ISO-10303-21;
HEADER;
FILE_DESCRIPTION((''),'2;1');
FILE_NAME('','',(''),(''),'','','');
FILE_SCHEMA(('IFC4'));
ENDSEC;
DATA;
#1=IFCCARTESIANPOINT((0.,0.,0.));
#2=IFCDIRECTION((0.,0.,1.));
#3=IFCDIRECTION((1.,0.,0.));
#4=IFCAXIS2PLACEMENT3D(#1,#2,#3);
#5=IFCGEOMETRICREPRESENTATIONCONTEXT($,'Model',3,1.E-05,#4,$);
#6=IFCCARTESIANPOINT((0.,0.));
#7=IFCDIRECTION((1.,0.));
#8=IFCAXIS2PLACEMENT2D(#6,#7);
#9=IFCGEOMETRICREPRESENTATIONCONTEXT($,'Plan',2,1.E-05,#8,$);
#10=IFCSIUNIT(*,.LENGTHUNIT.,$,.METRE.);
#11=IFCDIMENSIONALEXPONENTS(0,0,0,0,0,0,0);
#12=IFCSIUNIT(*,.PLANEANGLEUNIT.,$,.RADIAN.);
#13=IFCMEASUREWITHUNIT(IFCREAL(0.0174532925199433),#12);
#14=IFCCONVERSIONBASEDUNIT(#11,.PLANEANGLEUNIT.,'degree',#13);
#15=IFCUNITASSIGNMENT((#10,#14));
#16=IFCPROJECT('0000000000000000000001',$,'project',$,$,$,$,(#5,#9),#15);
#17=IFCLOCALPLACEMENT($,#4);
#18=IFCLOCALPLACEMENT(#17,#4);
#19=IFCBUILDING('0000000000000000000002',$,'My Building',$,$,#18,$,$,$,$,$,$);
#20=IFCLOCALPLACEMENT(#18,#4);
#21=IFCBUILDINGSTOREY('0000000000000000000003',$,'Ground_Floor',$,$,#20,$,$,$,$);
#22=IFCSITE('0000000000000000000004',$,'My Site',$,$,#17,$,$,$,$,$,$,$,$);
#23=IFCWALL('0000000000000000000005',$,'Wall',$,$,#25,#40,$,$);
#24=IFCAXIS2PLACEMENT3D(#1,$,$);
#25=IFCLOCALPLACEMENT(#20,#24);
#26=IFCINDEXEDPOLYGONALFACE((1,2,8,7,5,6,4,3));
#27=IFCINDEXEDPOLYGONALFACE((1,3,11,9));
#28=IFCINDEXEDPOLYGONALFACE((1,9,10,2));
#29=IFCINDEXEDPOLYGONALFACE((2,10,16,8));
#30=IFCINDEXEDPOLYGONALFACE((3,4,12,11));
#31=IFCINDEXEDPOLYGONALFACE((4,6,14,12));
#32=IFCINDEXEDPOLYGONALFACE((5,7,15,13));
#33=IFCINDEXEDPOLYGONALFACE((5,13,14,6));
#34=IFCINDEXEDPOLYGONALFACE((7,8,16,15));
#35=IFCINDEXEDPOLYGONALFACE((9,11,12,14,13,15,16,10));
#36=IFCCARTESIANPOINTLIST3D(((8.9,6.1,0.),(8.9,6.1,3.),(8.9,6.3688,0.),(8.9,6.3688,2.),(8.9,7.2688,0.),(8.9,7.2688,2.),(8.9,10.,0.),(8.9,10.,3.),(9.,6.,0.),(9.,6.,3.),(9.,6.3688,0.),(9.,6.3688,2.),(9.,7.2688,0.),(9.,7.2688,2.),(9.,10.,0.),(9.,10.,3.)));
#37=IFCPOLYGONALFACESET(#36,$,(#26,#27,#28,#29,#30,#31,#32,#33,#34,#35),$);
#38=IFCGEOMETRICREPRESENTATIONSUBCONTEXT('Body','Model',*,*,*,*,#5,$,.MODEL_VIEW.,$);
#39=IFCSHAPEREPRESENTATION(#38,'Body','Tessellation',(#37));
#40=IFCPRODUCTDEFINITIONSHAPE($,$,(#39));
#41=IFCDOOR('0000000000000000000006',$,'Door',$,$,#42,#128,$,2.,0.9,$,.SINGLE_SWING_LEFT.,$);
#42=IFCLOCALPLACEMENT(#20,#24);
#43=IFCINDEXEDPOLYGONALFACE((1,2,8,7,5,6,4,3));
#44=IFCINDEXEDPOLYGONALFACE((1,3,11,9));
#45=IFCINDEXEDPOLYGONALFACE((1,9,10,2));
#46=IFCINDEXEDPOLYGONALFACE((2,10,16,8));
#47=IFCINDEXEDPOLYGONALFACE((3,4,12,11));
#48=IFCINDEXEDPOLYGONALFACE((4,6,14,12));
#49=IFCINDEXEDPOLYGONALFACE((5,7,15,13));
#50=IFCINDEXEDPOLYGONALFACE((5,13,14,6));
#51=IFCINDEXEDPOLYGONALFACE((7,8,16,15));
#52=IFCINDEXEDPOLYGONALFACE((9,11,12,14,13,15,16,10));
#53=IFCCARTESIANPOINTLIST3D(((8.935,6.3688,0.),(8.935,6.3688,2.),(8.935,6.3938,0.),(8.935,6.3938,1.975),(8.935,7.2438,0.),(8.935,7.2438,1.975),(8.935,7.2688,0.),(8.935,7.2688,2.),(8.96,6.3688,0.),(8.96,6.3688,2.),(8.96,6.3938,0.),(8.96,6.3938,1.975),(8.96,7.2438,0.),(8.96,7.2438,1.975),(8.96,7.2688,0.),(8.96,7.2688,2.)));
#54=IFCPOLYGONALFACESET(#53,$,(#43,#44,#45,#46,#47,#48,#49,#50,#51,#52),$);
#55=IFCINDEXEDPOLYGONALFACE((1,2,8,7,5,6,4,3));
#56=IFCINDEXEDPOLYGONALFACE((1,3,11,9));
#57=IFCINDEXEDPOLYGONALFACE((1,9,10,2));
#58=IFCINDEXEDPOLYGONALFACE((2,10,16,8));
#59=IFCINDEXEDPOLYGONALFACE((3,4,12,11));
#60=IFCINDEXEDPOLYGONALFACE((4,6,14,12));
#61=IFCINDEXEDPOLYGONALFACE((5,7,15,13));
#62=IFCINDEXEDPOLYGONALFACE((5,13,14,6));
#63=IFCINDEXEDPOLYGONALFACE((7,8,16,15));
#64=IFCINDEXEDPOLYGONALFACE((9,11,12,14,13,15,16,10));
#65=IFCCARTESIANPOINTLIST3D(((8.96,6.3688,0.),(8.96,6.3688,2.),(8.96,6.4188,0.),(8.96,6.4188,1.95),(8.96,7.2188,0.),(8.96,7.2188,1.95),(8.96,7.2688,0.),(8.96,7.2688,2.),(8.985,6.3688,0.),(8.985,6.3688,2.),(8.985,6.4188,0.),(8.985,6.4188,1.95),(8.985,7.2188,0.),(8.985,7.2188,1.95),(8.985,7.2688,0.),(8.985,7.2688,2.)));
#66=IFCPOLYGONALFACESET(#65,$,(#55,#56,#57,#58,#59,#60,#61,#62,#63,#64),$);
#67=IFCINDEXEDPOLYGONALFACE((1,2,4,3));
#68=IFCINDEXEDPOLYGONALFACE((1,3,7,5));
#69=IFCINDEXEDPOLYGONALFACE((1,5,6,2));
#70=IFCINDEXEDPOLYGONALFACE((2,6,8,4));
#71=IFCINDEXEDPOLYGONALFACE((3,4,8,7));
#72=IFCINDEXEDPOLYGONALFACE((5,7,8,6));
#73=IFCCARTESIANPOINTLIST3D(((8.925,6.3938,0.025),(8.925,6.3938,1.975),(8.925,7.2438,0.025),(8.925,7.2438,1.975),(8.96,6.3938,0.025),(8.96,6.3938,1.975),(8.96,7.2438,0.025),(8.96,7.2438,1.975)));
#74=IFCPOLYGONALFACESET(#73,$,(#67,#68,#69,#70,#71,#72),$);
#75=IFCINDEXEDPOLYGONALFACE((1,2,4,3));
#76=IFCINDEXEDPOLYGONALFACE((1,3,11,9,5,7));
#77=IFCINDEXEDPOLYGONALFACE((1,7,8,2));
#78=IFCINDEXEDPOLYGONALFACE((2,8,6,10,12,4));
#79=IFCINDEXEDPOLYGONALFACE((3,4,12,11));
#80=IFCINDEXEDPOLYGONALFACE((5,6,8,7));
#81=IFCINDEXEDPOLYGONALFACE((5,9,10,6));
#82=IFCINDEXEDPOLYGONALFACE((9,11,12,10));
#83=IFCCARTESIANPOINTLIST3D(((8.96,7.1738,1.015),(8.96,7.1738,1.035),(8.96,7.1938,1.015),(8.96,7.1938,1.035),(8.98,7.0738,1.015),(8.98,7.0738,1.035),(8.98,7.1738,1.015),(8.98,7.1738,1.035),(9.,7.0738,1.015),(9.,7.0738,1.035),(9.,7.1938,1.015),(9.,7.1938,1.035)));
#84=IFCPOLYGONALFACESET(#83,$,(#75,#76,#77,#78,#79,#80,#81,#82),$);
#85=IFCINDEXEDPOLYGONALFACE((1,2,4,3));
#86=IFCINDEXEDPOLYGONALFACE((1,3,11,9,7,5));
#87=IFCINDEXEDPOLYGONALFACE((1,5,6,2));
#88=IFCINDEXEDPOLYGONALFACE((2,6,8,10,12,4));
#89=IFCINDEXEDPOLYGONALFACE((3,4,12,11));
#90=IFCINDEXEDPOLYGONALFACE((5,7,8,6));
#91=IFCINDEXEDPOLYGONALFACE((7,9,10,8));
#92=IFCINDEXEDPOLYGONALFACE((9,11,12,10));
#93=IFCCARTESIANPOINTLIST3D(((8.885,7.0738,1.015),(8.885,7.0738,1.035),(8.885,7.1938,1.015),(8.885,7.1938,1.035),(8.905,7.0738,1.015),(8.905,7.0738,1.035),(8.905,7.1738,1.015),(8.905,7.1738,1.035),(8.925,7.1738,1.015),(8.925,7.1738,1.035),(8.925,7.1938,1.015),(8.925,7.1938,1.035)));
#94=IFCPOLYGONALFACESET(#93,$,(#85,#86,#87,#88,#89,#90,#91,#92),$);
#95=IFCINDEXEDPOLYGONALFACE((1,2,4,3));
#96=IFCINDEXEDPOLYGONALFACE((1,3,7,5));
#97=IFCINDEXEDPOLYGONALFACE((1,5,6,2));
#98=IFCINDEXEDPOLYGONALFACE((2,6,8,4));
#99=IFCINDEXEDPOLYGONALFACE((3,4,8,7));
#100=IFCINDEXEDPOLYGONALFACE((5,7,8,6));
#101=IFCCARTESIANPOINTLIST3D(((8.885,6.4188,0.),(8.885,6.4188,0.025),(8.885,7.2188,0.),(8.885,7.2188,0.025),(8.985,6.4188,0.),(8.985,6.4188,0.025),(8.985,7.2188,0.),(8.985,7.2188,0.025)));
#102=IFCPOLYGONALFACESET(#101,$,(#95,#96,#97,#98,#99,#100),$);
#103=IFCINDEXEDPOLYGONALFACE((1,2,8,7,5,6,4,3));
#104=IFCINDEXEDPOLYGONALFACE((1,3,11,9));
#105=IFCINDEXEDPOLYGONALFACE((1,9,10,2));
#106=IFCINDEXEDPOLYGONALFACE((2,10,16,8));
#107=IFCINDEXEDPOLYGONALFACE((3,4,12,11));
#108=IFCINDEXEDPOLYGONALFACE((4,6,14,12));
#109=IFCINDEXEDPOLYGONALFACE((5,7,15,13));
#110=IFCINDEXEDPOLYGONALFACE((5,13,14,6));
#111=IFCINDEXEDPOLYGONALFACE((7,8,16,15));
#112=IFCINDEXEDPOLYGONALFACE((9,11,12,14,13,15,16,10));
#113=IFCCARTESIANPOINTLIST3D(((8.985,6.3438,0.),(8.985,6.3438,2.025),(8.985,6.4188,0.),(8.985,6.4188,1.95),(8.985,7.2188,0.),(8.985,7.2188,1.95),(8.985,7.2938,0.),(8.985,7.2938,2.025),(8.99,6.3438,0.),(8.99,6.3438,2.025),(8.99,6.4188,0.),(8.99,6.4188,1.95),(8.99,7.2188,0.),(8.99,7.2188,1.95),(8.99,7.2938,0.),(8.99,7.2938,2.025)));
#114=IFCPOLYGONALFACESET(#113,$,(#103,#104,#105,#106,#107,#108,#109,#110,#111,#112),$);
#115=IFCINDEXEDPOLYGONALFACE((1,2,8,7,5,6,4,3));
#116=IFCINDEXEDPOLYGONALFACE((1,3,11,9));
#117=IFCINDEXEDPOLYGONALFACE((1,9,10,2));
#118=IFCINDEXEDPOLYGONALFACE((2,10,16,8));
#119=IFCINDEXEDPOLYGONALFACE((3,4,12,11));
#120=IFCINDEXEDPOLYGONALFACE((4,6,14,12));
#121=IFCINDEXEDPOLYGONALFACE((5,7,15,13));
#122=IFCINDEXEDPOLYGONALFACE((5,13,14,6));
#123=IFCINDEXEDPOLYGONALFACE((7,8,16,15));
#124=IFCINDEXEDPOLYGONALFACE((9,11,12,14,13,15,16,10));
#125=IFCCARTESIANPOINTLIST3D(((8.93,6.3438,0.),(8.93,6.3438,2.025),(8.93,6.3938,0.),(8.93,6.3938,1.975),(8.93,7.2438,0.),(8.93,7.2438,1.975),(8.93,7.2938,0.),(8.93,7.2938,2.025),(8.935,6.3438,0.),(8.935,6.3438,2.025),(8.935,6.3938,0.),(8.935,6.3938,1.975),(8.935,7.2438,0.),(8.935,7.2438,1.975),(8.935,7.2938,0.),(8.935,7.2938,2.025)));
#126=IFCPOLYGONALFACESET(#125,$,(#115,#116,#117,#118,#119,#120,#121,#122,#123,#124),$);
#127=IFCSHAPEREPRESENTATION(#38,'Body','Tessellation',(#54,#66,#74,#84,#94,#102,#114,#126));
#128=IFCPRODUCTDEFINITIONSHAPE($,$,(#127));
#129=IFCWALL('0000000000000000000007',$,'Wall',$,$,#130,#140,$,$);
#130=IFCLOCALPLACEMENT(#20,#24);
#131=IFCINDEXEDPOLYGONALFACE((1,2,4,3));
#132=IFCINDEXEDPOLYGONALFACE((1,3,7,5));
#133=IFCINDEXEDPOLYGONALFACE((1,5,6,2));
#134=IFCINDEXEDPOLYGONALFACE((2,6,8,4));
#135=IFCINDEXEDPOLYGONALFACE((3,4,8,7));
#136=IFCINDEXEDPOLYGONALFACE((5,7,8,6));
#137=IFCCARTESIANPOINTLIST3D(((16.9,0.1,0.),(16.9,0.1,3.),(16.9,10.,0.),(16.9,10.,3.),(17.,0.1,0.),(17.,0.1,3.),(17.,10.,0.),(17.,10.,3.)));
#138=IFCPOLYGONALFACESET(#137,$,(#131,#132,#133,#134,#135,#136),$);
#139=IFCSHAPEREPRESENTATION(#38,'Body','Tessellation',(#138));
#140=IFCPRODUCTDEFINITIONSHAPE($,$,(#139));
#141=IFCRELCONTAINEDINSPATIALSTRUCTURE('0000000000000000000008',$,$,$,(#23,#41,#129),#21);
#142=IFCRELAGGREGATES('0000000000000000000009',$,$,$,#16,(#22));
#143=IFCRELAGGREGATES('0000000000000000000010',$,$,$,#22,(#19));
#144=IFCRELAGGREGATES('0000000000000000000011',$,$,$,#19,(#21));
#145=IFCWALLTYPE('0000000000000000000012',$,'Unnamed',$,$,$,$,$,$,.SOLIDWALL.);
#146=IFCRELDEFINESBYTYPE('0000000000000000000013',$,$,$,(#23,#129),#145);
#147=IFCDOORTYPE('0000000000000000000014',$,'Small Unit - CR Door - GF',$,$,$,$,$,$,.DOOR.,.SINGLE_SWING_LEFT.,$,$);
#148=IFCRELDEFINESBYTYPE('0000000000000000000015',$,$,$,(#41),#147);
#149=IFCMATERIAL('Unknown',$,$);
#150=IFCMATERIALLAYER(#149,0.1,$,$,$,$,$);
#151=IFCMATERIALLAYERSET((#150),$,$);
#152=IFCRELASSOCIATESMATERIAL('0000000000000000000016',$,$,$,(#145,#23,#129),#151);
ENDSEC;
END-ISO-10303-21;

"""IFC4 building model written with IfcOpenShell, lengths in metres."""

from ifc_helpers import new_model, entity, si_unit, converted_unit, frame, origin_with_axes, origin_2d_with_axis, place, context, subcontext, project, spatial, line, indexed_curve, outline, extrude, shape, source, transform, mapped, material, layer, layer_set, layer_usage, type_object, type_shapes, element, fill, save


model = new_model("IFC4")

# Units and contexts
model_context = context("Model", 3, precision=1e-05, world=origin_with_axes())
plan_context = context("Plan", 2, precision=1e-05, world=origin_2d_with_axis())
body_context_1 = subcontext(model_context, "Body", "Model", "MODEL_VIEW")
body_context_2 = subcontext(plan_context, "Body", "Plan", "PLAN_VIEW")
ifc_project = project(units=[si_unit("LENGTHUNIT", "METRE"), converted_unit("PLANEANGLEUNIT", "degree", entity("IfcReal", 0.0174532925199433), si_unit("PLANEANGLEUNIT", "RADIAN"), dimensions=[0, 0, 0, 0, 0, 0, 0])], contexts=[model_context, plan_context])

# Site, building, storey
site_placement = place(None, origin_with_axes())
site = spatial("IfcSite", under=ifc_project, at=site_placement, Name="My Site")
building_placement = place(site_placement, origin_with_axes())
building = spatial("IfcBuilding", under=site, at=building_placement, Name="My Building")
storey_placement = place(building_placement, origin_with_axes())
storey = spatial("IfcBuildingStorey", under=building, at=storey_placement, Name="Ground_Floor")

# Shared definitions
ifc_material = material(Name="Unknown")
ifc_layer = layer(ifc_material, 0.1)
ifc_layer_set = layer_set([ifc_layer])
wall_type = type_object("IfcWallType", Name="Unnamed", PredefinedType="SOLIDWALL", material=ifc_layer_set)

# Wall, opening, door
ifc_layer_usage_1 = layer_usage(ifc_layer_set, "AXIS2", "POSITIVE", 0.0)
wall_1_placement = place(storey_placement, frame((9.0, 6.0, 0.0), z_axis=(0.0, 0.0, 1.0), x_axis=(0.0, 1.0, 0.0)))
wall_1 = element("IfcWall", 1, at=wall_1_placement, inside=storey, type_object=wall_type, material=ifc_layer_usage_1, Name="Wall", context=body_context_1, shape_type="SweptSolid", body=[
    extrude(outline(indexed_curve([(0.0, 0.0), (0.1, 0.1), (4.0, 0.1), (4.0, 0.0)], segments=[line(1, 2, 3, 4, 1)])), origin_with_axes(), (0.0, 0.0, 1.0), 3.0),
])
shared_shape_1 = source(origin_with_axes(), body_context_1, "Body", "SweptSolid", [
    extrude(outline(indexed_curve([(0.0, 0.0), (0.9, 0.0), (0.9, 2.0), (0.0, 2.0)], segments=[line(1, 2, 3, 4, 1)])), frame((0.0, -0.6, 0.0), z_axis=(0.0, -1.0, 0.0), x_axis=(1.0, 0.0, 0.0)), (0.0, 0.0, -1.0), 1.2),
])
opening_1_placement = place(wall_1_placement, frame((0.3688, 0.015, 0.0), z_axis=(0.0, 0.0, 1.0), x_axis=(1.0, 0.0, 0.0)))
opening_1 = element("IfcOpeningElement", 2, at=opening_1_placement, cuts=wall_1, PredefinedType="OPENING", context=body_context_1, shape_type="MappedRepresentation", body=[
    mapped(shared_shape_1, transform((0.0, 0.0, 0.0), x_axis=(1.0, 0.0, 0.0), y_axis=(0.0, 1.0, 0.0), z_axis=(0.0, 0.0, 1.0), scale=1.0)),
])
door_type_1 = type_object("IfcDoorType", Name="Small Unit - CR Door - GF", OperationType="SINGLE_SWING_LEFT", PredefinedType="DOOR")
shared_shape_2 = source(origin_with_axes(), body_context_1, "Body", "SweptSolid", [
    extrude(outline(indexed_curve([(0.0, 0.0), (0.0, 2.0), (0.9, 2.0), (0.9, 0.0), (0.875, 0.0), (0.875, 1.975), (0.025, 1.975), (0.025, 0.0)], segments=[line(1, 2, 3, 4, 5, 6, 7, 8, 1)])), frame((0.0, 0.025, 0.0), z_axis=(0.0, -1.0, 0.0), x_axis=(1.0, 0.0, 0.0)), (0.0, 0.0, -1.0), 0.025),
    extrude(outline(indexed_curve([(0.0, 0.0), (0.0, 2.0), (0.9, 2.0), (0.9, 0.0), (0.85, 0.0), (0.85, 1.95), (0.05, 1.95), (0.05, 0.0)], segments=[line(1, 2, 3, 4, 5, 6, 7, 8, 1)])), frame((0.0, 0.0, 0.0), z_axis=(0.0, -1.0, 0.0), x_axis=(1.0, 0.0, 0.0)), (0.0, 0.0, -1.0), 0.025),
    extrude(outline(indexed_curve([(0.0, 0.0), (0.85, 0.0), (0.85, 0.035), (0.0, 0.035)], segments=[line(1, 2, 3, 4, 1)])), frame((0.025, 0.025, 0.025), z_axis=(0.0, 0.0, 1.0), x_axis=(1.0, 0.0, 0.0)), (0.0, 0.0, 1.0), 1.95),
    extrude(outline(indexed_curve([(0.0, 0.0), (0.0, -0.04), (-0.12, -0.04), (-0.12, -0.02), (-0.02, -0.02), (-0.02, 0.0)], segments=[line(1, 2, 3, 4, 5, 6, 1)])), frame((0.825, 0.025, 1.015), z_axis=(0.0, 0.0, 1.0), x_axis=(1.0, 0.0, 0.0)), (0.0, 0.0, 1.0), 0.02),
    extrude(outline(indexed_curve([(0.0, 0.0), (0.0, 0.04), (-0.12, 0.04), (-0.12, 0.02), (-0.02, 0.02), (-0.02, 0.0)], segments=[line(1, 2, 3, 4, 5, 6, 1)])), frame((0.825, 0.06, 1.015), z_axis=(0.0, 0.0, 1.0), x_axis=(1.0, 0.0, 0.0)), (0.0, 0.0, 1.0), 0.02),
    extrude(outline(indexed_curve([(0.0, 0.0), (0.8, 0.0), (0.8, 0.1), (0.0, 0.1)], segments=[line(1, 2, 3, 4, 1)])), frame((0.05, 0.0, 0.0), z_axis=(0.0, 0.0, 1.0), x_axis=(1.0, 0.0, 0.0)), (0.0, 0.0, 1.0), 0.025),
    extrude(outline(indexed_curve([(0.0, 0.0), (0.0, 2.025), (0.95, 2.025), (0.95, 0.0), (0.875, 0.0), (0.875, 1.95), (0.075, 1.95), (0.075, 0.0)], segments=[line(1, 2, 3, 4, 5, 6, 7, 8, 1)])), frame((-0.025, -0.005, 0.0), z_axis=(0.0, -1.0, 0.0), x_axis=(1.0, 0.0, 0.0)), (0.0, 0.0, -1.0), 0.005),
    extrude(outline(indexed_curve([(0.0, 0.0), (0.0, 2.025), (0.95, 2.025), (0.95, 0.0), (0.9, 0.0), (0.9, 1.975), (0.05, 1.975), (0.05, 0.0)], segments=[line(1, 2, 3, 4, 5, 6, 7, 8, 1)])), frame((-0.025, 0.05, 0.0), z_axis=(0.0, -1.0, 0.0), x_axis=(1.0, 0.0, 0.0)), (0.0, 0.0, -1.0), 0.005),
])
shared_shape_3 = source(origin_with_axes(), body_context_2, "Body", "Curve2D", [
    entity("IfcIndexedPolyCurve", entity("IfcCartesianPointList2D", [[0.0, 0.0], [0.0, 0.05], [0.025, 0.05], [0.025, 0.025], [0.05, 0.025], [0.05, 0.0]]), [entity("IfcLineIndex", [1, 2, 3, 4, 5, 6, 1])]),
    entity("IfcIndexedPolyCurve", entity("IfcCartesianPointList2D", [[0.9, 0.0], [0.9, 0.05], [0.875, 0.05], [0.875, 0.025], [0.85, 0.025], [0.85, 0.0]]), [entity("IfcLineIndex", [1, 2, 3, 4, 5, 6, 1])]),
    entity("IfcTrimmedCurve", entity("IfcEllipse", entity("IfcAxis2Placement2D", entity("IfcCartesianPoint", [0.06, 0.05]), entity("IfcDirection", [1.0, 0.0])), 0.815, 0.85), [entity("IfcCartesianPoint", [0.875, 0.05])], [entity("IfcCartesianPoint", [0.06, 0.9])], True, "CARTESIAN"),
    entity("IfcIndexedPolyCurve", entity("IfcCartesianPointList2D", [[0.025, 0.05], [0.06, 0.05], [0.06, 0.9], [0.025, 0.9]]), [entity("IfcLineIndex", [1, 2, 3, 4, 1])]),
])
type_shapes(door_type_1, [shared_shape_2, shared_shape_3])
door_1_placement = place(opening_1_placement, frame((0.0, 0.0, 0.0), z_axis=(0.0, 0.0, 1.0), x_axis=(1.0, 0.0, 0.0)))
door_1 = element("IfcDoor", 3, at=door_1_placement, inside=storey, type_object=door_type_1, Name="Door", OperationType="SINGLE_SWING_LEFT", OverallHeight=2.0, OverallWidth=0.9, shapes=[
    shape(body_context_1, "Body", "MappedRepresentation", [mapped(shared_shape_2, transform((0.0, 0.0, 0.0), x_axis=(1.0, 0.0, 0.0), y_axis=(0.0, 1.0, 0.0), z_axis=(0.0, 0.0, 1.0), scale=1.0))]),
    shape(body_context_2, "Body", "MappedRepresentation", [mapped(shared_shape_3, transform((0.0, 0.0, 0.0), x_axis=(1.0, 0.0, 0.0), y_axis=(0.0, 1.0, 0.0), z_axis=(0.0, 0.0, 1.0), scale=1.0))]),
])
fill(opening_1, door_1)

# Wall
ifc_layer_usage_2 = layer_usage(ifc_layer_set, "AXIS2", "POSITIVE", 0.0)
wall_2_placement = place(storey_placement, frame((17.0, 0.0, 0.0), z_axis=(0.0, 0.0, 1.0), x_axis=(0.0, 1.0, 0.0)))
element("IfcWall", 4, at=wall_2_placement, inside=storey, type_object=wall_type, material=ifc_layer_usage_2, Name="Wall", context=body_context_1, shape_type="SweptSolid", body=[
    extrude(outline(indexed_curve([(0.1, 0.0), (0.1, 0.1), (10.0, 0.1), (10.0, 0.0)], segments=[line(1, 2, 3, 4, 1)])), origin_with_axes(), (0.0, 0.0, 1.0), 3.0),
])

save(model, "model.ifc")
